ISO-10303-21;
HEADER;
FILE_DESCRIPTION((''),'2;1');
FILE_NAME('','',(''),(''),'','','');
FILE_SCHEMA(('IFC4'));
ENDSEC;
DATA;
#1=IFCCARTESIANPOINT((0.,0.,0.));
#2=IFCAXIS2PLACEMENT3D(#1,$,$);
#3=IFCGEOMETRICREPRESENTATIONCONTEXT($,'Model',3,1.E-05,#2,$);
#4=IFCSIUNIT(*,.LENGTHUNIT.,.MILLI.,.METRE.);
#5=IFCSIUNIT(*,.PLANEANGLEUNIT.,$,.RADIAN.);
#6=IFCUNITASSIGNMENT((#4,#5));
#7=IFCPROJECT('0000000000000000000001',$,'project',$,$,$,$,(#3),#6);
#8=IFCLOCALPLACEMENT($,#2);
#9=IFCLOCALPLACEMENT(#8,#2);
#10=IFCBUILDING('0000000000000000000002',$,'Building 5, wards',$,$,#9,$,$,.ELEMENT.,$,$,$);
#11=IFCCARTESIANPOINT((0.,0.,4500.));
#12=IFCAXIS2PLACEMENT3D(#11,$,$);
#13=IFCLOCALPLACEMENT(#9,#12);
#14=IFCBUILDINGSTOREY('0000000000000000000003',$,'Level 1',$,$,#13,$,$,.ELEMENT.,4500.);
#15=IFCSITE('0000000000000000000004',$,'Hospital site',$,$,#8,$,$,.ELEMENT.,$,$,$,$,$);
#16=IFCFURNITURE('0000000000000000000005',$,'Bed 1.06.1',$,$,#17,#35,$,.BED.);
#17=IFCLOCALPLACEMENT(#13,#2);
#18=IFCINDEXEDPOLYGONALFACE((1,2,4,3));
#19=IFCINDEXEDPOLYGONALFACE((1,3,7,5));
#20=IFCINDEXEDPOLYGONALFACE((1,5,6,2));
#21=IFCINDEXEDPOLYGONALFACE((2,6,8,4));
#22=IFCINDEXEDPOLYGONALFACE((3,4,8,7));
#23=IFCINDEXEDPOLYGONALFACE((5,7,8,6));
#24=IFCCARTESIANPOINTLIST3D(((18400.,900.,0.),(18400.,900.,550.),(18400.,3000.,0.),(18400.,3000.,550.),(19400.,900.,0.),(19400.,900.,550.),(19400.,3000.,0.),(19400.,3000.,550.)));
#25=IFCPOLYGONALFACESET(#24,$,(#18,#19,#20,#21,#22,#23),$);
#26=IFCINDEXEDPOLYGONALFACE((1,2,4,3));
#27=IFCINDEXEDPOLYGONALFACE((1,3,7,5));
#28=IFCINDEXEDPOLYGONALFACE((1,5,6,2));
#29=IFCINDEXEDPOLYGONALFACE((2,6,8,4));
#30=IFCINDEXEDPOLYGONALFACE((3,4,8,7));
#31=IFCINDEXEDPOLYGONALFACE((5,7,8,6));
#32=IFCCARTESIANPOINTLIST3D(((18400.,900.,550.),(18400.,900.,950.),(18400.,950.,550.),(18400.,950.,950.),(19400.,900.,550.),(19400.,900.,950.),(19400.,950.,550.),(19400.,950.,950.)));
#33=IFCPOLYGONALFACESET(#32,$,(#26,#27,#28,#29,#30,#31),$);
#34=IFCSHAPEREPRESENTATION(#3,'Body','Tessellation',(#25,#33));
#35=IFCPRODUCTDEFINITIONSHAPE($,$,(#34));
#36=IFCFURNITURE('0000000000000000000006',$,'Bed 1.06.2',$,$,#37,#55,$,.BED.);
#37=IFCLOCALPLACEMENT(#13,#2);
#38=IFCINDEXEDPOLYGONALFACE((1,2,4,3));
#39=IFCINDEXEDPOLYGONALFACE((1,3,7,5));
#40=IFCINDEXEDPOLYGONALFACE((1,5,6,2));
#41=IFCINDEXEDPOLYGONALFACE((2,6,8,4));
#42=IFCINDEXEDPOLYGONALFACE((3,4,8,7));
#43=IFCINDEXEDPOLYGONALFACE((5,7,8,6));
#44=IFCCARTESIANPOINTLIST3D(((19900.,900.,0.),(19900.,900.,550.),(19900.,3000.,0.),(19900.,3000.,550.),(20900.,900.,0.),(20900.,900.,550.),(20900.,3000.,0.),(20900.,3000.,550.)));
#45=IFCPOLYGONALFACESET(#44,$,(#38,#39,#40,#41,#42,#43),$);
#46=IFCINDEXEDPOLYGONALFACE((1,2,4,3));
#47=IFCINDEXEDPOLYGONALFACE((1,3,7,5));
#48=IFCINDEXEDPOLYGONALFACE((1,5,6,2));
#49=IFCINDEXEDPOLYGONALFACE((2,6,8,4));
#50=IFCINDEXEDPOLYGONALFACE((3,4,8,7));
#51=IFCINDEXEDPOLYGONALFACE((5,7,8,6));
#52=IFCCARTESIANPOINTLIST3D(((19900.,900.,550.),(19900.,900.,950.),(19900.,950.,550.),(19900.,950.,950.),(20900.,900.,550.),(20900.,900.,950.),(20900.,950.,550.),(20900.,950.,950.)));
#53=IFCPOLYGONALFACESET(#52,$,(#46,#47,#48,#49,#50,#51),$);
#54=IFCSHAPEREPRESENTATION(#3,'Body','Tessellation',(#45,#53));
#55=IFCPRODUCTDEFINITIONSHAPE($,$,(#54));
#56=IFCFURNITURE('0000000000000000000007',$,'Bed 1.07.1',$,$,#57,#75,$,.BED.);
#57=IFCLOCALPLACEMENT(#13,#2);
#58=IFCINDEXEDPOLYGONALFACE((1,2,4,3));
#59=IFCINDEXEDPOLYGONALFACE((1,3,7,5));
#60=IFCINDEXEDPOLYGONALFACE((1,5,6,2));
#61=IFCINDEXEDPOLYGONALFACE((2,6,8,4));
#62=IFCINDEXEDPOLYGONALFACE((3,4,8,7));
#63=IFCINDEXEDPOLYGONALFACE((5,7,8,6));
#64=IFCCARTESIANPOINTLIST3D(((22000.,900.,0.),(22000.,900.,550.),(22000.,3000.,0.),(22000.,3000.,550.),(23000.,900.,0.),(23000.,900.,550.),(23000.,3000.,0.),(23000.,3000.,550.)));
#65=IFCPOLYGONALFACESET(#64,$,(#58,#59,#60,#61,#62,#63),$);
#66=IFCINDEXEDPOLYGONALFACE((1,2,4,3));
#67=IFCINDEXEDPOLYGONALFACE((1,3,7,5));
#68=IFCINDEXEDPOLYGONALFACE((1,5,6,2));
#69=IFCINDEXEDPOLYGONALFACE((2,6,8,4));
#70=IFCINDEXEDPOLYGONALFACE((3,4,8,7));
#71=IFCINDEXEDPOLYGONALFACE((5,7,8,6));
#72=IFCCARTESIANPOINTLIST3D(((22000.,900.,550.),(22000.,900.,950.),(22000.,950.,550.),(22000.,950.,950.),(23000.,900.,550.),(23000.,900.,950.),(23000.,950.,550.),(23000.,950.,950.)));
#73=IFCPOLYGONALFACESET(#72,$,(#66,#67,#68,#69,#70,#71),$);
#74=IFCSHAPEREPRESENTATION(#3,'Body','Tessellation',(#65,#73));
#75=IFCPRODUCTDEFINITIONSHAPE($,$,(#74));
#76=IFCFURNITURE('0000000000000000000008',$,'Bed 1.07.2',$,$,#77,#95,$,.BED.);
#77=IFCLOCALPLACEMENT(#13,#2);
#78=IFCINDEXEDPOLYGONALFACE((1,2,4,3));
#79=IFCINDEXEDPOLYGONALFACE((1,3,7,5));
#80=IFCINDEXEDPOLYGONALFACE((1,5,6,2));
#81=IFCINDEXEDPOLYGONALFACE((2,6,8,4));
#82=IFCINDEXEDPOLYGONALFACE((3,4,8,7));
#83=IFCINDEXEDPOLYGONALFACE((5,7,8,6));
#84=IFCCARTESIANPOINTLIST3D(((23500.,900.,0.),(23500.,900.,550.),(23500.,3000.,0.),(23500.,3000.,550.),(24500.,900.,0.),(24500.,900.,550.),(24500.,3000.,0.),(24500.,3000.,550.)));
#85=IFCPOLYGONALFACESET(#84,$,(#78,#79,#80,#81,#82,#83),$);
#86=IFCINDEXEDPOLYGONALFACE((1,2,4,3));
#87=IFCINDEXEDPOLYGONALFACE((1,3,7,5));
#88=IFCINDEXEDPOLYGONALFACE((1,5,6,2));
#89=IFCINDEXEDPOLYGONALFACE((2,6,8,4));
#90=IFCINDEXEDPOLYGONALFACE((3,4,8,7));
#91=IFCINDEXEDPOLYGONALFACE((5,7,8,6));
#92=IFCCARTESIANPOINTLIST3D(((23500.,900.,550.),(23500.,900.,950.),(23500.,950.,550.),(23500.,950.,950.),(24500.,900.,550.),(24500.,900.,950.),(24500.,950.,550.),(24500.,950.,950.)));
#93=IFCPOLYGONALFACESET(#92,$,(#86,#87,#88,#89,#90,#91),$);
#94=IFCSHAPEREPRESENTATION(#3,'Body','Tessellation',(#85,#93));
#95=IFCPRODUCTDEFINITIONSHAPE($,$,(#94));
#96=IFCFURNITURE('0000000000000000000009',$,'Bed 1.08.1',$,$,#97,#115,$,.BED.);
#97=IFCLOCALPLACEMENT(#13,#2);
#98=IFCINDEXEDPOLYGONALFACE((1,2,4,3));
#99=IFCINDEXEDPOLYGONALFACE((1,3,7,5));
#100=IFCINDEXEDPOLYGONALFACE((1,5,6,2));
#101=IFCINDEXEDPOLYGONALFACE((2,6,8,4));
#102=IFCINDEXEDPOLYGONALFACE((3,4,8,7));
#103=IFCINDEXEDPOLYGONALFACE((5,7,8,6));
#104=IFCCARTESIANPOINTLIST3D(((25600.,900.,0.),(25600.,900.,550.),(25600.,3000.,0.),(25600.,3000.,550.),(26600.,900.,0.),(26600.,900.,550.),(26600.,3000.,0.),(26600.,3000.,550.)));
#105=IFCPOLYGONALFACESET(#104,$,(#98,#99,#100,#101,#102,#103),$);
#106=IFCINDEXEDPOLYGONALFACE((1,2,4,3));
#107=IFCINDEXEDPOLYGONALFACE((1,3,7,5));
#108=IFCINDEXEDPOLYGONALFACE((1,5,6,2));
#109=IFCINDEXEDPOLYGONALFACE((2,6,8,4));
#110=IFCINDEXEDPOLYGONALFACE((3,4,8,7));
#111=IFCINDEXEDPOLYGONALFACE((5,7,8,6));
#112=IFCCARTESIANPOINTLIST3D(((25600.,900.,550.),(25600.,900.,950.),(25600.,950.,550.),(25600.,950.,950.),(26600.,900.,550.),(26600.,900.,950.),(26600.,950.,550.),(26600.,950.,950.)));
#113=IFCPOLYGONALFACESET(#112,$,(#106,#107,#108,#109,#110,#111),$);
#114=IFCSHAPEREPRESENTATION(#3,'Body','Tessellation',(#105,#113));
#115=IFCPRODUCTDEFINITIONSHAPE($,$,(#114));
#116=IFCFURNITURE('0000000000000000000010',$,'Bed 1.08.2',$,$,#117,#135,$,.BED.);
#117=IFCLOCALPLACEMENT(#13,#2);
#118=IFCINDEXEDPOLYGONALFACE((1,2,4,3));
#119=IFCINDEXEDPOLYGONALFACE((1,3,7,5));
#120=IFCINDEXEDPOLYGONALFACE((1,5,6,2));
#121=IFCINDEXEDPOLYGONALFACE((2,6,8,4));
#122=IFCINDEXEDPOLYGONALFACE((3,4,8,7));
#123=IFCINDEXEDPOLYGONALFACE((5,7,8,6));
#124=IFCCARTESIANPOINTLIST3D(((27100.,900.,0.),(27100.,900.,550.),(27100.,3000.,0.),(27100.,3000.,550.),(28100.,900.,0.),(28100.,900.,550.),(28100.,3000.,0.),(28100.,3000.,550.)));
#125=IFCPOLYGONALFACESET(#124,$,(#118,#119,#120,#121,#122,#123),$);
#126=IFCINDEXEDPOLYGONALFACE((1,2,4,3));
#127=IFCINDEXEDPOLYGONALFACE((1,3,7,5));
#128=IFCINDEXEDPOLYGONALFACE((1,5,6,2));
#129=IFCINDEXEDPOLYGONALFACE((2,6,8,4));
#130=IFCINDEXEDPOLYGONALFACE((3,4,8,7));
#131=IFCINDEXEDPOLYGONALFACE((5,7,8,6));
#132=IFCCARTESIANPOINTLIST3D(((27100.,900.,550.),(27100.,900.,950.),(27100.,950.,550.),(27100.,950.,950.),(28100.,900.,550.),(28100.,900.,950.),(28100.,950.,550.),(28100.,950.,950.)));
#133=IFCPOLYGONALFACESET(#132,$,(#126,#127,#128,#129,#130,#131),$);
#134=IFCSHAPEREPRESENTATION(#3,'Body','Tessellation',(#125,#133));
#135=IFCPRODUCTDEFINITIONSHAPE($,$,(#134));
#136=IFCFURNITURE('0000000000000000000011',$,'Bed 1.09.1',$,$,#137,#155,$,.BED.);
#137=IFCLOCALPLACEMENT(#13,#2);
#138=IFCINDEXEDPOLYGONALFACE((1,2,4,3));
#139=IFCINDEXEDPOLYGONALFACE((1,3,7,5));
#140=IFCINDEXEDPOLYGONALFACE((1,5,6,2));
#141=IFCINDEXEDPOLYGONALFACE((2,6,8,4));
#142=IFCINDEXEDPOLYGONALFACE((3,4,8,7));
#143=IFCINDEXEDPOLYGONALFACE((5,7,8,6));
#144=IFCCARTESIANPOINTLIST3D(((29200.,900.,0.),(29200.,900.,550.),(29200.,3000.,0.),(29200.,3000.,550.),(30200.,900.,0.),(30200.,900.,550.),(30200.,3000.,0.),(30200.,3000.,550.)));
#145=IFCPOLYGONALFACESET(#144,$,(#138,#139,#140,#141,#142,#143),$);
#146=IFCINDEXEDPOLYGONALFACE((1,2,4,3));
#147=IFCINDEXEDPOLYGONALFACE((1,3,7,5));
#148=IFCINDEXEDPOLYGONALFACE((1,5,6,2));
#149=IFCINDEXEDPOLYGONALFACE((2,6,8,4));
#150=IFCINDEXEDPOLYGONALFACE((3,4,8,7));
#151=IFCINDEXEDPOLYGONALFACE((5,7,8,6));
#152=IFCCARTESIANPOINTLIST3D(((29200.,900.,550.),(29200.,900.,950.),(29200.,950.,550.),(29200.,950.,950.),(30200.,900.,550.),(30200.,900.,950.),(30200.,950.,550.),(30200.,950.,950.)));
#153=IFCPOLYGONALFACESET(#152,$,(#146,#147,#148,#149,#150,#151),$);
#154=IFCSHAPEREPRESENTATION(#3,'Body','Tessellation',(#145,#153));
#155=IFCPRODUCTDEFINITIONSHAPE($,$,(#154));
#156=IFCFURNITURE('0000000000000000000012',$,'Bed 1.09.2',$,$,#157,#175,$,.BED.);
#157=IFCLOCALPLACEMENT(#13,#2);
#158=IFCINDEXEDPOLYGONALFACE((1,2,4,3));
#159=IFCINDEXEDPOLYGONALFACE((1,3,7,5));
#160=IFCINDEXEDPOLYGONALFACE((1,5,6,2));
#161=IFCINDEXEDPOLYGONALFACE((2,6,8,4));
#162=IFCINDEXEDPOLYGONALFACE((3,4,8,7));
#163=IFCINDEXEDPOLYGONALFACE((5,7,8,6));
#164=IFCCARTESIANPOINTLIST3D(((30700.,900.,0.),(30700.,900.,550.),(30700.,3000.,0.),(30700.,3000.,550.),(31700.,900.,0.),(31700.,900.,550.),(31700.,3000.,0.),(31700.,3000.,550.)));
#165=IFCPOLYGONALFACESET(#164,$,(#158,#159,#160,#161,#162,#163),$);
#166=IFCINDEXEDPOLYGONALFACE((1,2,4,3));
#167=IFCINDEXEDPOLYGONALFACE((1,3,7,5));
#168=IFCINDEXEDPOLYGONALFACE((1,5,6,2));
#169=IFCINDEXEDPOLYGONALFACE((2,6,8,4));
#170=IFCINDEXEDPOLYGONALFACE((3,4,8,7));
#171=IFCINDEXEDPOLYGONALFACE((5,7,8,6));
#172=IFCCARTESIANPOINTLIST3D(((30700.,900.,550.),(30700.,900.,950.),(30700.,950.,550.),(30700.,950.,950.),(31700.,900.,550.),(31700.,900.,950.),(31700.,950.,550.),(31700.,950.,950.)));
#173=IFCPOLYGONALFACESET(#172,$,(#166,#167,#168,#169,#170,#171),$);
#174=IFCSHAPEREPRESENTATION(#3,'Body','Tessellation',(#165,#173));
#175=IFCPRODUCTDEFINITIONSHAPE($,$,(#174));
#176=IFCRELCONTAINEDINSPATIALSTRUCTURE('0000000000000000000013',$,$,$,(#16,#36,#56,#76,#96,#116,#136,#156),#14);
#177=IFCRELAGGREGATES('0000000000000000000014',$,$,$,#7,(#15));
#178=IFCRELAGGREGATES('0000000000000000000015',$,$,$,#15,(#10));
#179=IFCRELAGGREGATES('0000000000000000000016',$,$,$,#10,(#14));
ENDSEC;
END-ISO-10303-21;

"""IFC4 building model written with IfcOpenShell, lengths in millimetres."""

from ifc_helpers import new_model, si_unit, frame, frame_2d, origin, place, context, project, spatial, rectangle, extrude, element, save


model = new_model("IFC4")

# Units and contexts
model_context = context("Model", 3, precision=1e-05, world=origin())
ifc_project = project(units=[si_unit("LENGTHUNIT", "METRE", prefix="MILLI"), si_unit("PLANEANGLEUNIT", "RADIAN")], contexts=[model_context])

# Site, building, storey
site_placement = place(None, origin())
site = spatial("IfcSite", under=ifc_project, at=site_placement, Name="Hospital site", CompositionType="ELEMENT")
building_placement = place(site_placement, origin())
building = spatial("IfcBuilding", under=site, at=building_placement, Name="Building 5, wards", CompositionType="ELEMENT")
storey_placement = place(building_placement, frame((0.0, 0.0, 4500.0)))
storey = spatial("IfcBuildingStorey", under=building, at=storey_placement, Name="Level 1", CompositionType="ELEMENT", Elevation=4500.0)

# Furniture
for number, where, name in (
    (1, (18400.0, 900.0, 0.0), "Bed 1.06.1"),
    (2, (19900.0, 900.0, 0.0), "Bed 1.06.2"),
    (3, (22000.0, 900.0, 0.0), "Bed 1.07.1"),
    (4, (23500.0, 900.0, 0.0), "Bed 1.07.2"),
    (5, (25600.0, 900.0, 0.0), "Bed 1.08.1"),
    (6, (27100.0, 900.0, 0.0), "Bed 1.08.2"),
    (7, (29200.0, 900.0, 0.0), "Bed 1.09.1"),
    (8, (30700.0, 900.0, 0.0), "Bed 1.09.2"),
):
    element("IfcFurniture", number, at=place(storey_placement, frame(where)), inside=storey, Name=name, PredefinedType="BED", context=model_context, shape_type="SweptSolid", body=[
        extrude(rectangle(XDim=1000.0, YDim=2100.0, at=frame_2d((500.0, 1050.0))), origin(), (0.0, 0.0, 1.0), 550.0),
        extrude(rectangle(XDim=1000.0, YDim=50.0, at=frame_2d((500.0, 25.0))), frame((0.0, 0.0, 550.0)), (0.0, 0.0, 1.0), 400.0),
    ])

save(model, "model.ifc")
